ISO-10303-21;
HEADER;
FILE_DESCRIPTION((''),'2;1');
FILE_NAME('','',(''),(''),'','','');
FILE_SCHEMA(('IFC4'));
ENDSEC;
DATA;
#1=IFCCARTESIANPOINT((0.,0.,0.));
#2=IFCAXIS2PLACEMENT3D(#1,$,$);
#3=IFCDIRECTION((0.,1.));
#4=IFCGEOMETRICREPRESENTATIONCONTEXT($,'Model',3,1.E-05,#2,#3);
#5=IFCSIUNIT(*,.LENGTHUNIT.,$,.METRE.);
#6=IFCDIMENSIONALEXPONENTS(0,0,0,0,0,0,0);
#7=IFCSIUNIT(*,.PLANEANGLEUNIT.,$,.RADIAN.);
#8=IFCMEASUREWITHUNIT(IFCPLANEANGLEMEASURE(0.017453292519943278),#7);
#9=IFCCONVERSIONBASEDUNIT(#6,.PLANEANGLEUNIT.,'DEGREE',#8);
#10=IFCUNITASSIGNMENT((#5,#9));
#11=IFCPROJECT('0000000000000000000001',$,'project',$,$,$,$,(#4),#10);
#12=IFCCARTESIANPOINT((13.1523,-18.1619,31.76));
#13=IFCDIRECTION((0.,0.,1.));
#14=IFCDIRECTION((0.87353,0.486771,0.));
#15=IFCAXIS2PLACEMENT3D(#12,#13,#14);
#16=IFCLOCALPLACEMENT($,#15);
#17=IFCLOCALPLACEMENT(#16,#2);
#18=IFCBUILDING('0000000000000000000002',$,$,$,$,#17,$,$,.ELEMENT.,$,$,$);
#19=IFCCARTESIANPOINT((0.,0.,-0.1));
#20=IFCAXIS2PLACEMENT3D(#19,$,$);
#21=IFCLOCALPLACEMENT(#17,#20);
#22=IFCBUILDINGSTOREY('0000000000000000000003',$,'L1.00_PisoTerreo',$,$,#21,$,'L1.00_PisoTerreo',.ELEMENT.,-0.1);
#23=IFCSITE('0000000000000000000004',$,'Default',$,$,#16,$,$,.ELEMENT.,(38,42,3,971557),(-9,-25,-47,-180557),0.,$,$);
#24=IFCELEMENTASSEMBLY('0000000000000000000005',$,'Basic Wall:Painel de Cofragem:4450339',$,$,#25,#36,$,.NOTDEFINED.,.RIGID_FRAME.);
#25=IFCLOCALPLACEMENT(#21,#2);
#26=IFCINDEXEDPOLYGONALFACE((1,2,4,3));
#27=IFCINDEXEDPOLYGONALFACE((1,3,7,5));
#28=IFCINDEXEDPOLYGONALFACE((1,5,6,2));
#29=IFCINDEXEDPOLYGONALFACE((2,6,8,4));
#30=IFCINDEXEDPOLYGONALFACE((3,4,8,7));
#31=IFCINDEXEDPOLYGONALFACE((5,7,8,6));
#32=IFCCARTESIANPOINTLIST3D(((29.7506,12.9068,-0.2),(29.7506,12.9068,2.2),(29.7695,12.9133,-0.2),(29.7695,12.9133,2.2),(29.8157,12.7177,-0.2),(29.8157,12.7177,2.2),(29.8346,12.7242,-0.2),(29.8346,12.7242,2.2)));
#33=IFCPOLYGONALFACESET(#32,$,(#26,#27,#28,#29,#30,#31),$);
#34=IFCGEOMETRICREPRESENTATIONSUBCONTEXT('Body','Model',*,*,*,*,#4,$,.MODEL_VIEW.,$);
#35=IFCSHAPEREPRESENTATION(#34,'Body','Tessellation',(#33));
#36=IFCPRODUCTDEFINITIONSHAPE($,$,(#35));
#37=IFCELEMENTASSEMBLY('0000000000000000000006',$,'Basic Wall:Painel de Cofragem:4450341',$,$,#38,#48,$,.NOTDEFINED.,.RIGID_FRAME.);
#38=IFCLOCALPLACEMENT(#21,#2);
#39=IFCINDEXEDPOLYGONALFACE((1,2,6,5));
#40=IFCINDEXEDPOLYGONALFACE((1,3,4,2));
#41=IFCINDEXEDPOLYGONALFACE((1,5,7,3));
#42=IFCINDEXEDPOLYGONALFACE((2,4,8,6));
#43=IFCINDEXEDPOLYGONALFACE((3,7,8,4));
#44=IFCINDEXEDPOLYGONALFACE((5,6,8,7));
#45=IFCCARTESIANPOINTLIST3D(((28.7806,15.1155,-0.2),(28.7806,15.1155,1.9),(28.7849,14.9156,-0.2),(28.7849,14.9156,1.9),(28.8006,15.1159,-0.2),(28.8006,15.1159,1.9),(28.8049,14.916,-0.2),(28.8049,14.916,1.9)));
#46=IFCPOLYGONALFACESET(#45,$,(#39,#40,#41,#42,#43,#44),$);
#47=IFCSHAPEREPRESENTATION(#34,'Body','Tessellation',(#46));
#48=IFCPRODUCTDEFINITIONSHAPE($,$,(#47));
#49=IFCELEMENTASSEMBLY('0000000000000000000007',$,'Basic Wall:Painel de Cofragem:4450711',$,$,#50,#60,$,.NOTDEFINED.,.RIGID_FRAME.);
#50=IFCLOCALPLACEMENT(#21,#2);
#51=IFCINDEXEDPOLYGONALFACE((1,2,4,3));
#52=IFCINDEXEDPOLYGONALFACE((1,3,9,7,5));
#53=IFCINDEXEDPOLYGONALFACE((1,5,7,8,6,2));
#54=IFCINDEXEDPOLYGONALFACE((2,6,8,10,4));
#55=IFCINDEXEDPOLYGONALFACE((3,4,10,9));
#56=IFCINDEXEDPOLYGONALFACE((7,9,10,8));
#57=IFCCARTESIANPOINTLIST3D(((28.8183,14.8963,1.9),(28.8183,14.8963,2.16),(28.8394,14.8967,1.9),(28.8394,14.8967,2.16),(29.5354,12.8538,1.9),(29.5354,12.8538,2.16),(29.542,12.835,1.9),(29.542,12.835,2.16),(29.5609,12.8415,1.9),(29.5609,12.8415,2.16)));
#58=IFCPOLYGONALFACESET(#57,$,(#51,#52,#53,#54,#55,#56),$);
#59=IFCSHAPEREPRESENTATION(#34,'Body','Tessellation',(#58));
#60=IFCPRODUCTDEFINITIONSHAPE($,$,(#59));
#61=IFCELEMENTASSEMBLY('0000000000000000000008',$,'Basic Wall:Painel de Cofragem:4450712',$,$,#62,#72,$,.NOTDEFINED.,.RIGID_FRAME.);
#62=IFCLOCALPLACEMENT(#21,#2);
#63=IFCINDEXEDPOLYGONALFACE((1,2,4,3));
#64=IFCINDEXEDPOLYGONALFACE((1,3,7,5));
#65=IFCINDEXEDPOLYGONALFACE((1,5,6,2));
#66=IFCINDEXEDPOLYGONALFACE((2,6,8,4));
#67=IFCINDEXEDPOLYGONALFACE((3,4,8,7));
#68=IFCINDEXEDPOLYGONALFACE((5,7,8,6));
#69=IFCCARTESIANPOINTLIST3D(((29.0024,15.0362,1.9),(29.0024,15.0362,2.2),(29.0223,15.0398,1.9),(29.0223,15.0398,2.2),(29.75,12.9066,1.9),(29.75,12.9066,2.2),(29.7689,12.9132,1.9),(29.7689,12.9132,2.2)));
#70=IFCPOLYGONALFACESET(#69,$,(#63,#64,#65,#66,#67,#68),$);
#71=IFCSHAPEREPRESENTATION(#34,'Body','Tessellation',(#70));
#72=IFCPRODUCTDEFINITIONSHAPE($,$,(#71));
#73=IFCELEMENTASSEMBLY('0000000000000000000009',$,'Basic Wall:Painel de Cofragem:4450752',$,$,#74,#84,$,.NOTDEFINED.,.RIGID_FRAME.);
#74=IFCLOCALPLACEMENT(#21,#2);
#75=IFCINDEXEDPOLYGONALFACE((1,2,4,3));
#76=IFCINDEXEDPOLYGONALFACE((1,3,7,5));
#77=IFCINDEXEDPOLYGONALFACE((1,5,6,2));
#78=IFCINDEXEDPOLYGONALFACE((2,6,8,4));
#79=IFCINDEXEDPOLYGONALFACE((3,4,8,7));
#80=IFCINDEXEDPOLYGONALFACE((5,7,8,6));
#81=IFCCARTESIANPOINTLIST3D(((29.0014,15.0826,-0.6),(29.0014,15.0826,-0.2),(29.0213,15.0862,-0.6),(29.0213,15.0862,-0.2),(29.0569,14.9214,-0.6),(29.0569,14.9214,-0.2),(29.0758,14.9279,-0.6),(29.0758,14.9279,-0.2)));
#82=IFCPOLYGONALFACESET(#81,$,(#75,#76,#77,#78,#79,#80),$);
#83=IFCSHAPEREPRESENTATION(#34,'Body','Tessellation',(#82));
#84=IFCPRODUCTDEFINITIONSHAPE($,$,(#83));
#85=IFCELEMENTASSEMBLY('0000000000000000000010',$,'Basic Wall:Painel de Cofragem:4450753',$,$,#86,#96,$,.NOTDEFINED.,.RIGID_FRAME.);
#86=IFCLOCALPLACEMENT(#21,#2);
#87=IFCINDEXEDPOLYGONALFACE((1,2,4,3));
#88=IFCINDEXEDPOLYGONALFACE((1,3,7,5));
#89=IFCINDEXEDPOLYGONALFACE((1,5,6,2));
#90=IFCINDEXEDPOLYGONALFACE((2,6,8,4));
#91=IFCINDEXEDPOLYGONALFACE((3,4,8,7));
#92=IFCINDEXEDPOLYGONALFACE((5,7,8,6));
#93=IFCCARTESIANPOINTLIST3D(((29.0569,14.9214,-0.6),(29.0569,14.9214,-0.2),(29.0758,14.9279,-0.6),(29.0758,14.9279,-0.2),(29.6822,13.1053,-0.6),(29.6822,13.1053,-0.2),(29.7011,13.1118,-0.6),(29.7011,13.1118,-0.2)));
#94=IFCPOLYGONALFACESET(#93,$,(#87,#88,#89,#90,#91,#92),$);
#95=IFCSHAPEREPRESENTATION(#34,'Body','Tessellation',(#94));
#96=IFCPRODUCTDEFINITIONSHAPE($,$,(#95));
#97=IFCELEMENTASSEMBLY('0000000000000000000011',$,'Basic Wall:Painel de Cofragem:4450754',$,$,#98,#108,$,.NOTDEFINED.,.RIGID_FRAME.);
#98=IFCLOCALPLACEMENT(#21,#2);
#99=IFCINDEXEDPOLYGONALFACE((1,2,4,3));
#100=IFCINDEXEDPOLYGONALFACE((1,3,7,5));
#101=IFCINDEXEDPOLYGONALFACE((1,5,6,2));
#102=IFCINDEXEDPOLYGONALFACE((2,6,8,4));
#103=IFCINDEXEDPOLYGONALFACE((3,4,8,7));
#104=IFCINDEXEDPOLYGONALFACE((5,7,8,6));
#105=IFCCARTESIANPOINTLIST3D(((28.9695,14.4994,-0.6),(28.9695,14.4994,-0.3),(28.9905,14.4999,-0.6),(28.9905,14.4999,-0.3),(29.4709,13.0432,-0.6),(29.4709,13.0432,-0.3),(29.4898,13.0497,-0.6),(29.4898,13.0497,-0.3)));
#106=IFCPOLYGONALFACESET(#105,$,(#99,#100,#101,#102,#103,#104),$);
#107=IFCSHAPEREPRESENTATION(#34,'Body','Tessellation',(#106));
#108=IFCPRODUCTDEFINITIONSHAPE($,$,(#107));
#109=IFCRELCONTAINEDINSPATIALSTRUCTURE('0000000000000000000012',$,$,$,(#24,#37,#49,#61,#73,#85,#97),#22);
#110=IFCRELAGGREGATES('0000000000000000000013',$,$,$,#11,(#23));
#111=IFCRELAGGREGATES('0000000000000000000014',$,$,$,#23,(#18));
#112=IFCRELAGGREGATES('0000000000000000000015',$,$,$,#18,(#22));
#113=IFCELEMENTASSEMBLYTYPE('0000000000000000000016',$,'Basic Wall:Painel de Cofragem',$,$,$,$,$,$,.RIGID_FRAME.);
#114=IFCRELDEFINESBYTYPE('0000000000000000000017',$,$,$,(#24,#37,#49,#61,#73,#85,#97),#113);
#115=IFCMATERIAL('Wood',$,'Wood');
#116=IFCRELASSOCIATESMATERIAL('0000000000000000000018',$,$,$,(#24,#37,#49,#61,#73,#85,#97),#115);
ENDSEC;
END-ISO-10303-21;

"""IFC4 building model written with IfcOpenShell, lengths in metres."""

from ifc_helpers import new_model, entity, si_unit, converted_unit, direction, frame, origin, place, context, subcontext, project, spatial, indexed_curve, outline, extrude, material, type_object, element, save


model = new_model("IFC4")

# Units and contexts
model_context = context("Model", 3, precision=1e-05, world=origin(), true_north=direction((0.0, 1.0)))
body_context = subcontext(model_context, "Body", "Model", "MODEL_VIEW")
ifc_project = project(units=[si_unit("LENGTHUNIT", "METRE"), converted_unit("PLANEANGLEUNIT", "DEGREE", entity("IfcPlaneAngleMeasure", 0.017453292519943278), si_unit("PLANEANGLEUNIT", "RADIAN"), dimensions=[0, 0, 0, 0, 0, 0, 0])], contexts=[model_context])

# Site, building, storey
site_placement = place(None, frame((13.1523, -18.1619, 31.76), z_axis=(0.0, 0.0, 1.0), x_axis=(0.87353, 0.486771, 0.0)))
site = spatial("IfcSite", under=ifc_project, at=site_placement, Name="Default", CompositionType="ELEMENT", RefLatitude=(38, 42, 3, 971557), RefLongitude=(-9, -25, -47, -180557), RefElevation=0.0)
building_placement = place(site_placement, origin())
building = spatial("IfcBuilding", under=site, at=building_placement, CompositionType="ELEMENT")
storey_placement = place(building_placement, frame((0.0, 0.0, -0.1)))
storey = spatial("IfcBuildingStorey", under=building, at=storey_placement, Name="L1.00_PisoTerreo", LongName="L1.00_PisoTerreo", CompositionType="ELEMENT", Elevation=-0.1)

# Element assemblies
ifc_material_1 = material(Name="Wood", Category="Wood")
element_assembly_type = type_object("IfcElementAssemblyType", Name="Basic Wall:Painel de Cofragem", PredefinedType="RIGID_FRAME")
assembly_1_placement = place(storey_placement, frame((29.76, 12.91, -0.2), z_axis=(0.0, 0.0, 1.0), x_axis=(0.325568, -0.945519, 0.0)))
element("IfcElementAssembly", 1, at=assembly_1_placement, inside=storey, type_object=element_assembly_type, material=ifc_material_1, Name="Basic Wall:Painel de Cofragem:4450339", AssemblyPlace="NOTDEFINED", PredefinedType="RIGID_FRAME", context=body_context, shape_type="SweptSolid", body=[
    extrude(outline(indexed_curve([(0.2, 0.01), (0.0, 0.01), (0.0, -0.01), (0.2, -0.01), (0.2, 0.01)], self_intersect=False)), origin(), (0.0, 0.0, 1.0), 2.4),
])
assembly_2_placement = place(storey_placement, frame((28.7906, 15.1157, -0.2), z_axis=(0.0, 0.0, 1.0), x_axis=(0.021581, -0.999767, 0.0)))
element("IfcElementAssembly", 2, at=assembly_2_placement, inside=storey, type_object=element_assembly_type, material=ifc_material_1, Name="Basic Wall:Painel de Cofragem:4450341", AssemblyPlace="NOTDEFINED", PredefinedType="RIGID_FRAME", context=body_context, shape_type="SweptSolid", body=[
    extrude(outline(indexed_curve([(0.2, 0.01), (0.0, 0.01), (0.0, -0.01), (0.2, -0.01), (0.2, 0.01)], self_intersect=False)), origin(), (0.0, 0.0, 1.0), 2.1),
])
assembly_3_placement = place(storey_placement, frame((29.5515, 12.8382, 1.9), z_axis=(0.0, 0.0, 1.0), x_axis=(-0.331244, 0.943545, 0.0)))
element("IfcElementAssembly", 3, at=assembly_3_placement, inside=storey, type_object=element_assembly_type, material=ifc_material_1, Name="Basic Wall:Painel de Cofragem:4450711", AssemblyPlace="NOTDEFINED", PredefinedType="RIGID_FRAME", context=body_context, shape_type="SweptSolid", body=[
    extrude(outline(indexed_curve([(2.1782, -0.01), (2.1848, 0.01), (0.0201, 0.01), (0.0001, 0.01), (0.0, -0.01), (2.1782, -0.01)], self_intersect=False)), origin(), (0.0, 0.0, 1.0), 0.26),
])
assembly_4_placement = place(storey_placement, frame((29.7594, 12.9099, 1.9), z_axis=(0.0, 0.0, 1.0), x_axis=(-0.331244, 0.943545, 0.0)))
element("IfcElementAssembly", 4, at=assembly_4_placement, inside=storey, type_object=element_assembly_type, material=ifc_material_1, Name="Basic Wall:Painel de Cofragem:4450712", AssemblyPlace="NOTDEFINED", PredefinedType="RIGID_FRAME", context=body_context, shape_type="SweptSolid", body=[
    extrude(outline(indexed_curve([(2.2539, -0.01), (2.257, 0.01), (0.0, 0.01), (0.0, -0.01), (2.2539, -0.01)], self_intersect=False)), origin(), (0.0, 0.0, 1.0), 0.3),
])
assembly_5_placement = place(storey_placement, frame((29.0108, 15.0859, -0.6), z_axis=(0.0, 0.0, 1.0), x_axis=(0.325568, -0.945519, 0.0)))
element("IfcElementAssembly", 5, at=assembly_5_placement, inside=storey, type_object=element_assembly_type, material=ifc_material_1, Name="Basic Wall:Painel de Cofragem:4450752", AssemblyPlace="NOTDEFINED", PredefinedType="RIGID_FRAME", context=body_context, shape_type="SweptSolid", body=[
    extrude(outline(indexed_curve([(0.1705, -0.01), (0.1705, 0.01), (0.0031, 0.01), (0.0, -0.01), (0.1705, -0.01)], self_intersect=False)), origin(), (0.0, 0.0, 1.0), 0.4),
])
assembly_6_placement = place(storey_placement, frame((29.6916, 13.1086, -0.6), z_axis=(0.0, 0.0, 1.0), x_axis=(-0.325568, 0.945519, 0.0)))
element("IfcElementAssembly", 6, at=assembly_6_placement, inside=storey, type_object=element_assembly_type, material=ifc_material_1, Name="Basic Wall:Painel de Cofragem:4450753", AssemblyPlace="NOTDEFINED", PredefinedType="RIGID_FRAME", context=body_context, shape_type="SweptSolid", body=[
    extrude(outline(indexed_curve([(1.9207, 0.01), (0.0, 0.01), (0.0, -0.01), (1.9207, -0.01), (1.9207, 0.01)], self_intersect=False)), origin(), (0.0, 0.0, 1.0), 0.4),
])
assembly_7_placement = place(storey_placement, frame((29.4804, 13.0464, -0.6), z_axis=(0.0, 0.0, 1.0), x_axis=(-0.325568, 0.945519, 0.0)))
element("IfcElementAssembly", 7, at=assembly_7_placement, inside=storey, type_object=element_assembly_type, material=ifc_material_1, Name="Basic Wall:Painel de Cofragem:4450754", AssemblyPlace="NOTDEFINED", PredefinedType="RIGID_FRAME", context=body_context, shape_type="SweptSolid", body=[
    extrude(outline(indexed_curve([(1.5338, -0.01), (1.5402, 0.01), (0.0, 0.01), (0.0, -0.01), (1.5338, -0.01)], self_intersect=False)), origin(), (0.0, 0.0, 1.0), 0.3),
])

save(model, "model.ifc")
